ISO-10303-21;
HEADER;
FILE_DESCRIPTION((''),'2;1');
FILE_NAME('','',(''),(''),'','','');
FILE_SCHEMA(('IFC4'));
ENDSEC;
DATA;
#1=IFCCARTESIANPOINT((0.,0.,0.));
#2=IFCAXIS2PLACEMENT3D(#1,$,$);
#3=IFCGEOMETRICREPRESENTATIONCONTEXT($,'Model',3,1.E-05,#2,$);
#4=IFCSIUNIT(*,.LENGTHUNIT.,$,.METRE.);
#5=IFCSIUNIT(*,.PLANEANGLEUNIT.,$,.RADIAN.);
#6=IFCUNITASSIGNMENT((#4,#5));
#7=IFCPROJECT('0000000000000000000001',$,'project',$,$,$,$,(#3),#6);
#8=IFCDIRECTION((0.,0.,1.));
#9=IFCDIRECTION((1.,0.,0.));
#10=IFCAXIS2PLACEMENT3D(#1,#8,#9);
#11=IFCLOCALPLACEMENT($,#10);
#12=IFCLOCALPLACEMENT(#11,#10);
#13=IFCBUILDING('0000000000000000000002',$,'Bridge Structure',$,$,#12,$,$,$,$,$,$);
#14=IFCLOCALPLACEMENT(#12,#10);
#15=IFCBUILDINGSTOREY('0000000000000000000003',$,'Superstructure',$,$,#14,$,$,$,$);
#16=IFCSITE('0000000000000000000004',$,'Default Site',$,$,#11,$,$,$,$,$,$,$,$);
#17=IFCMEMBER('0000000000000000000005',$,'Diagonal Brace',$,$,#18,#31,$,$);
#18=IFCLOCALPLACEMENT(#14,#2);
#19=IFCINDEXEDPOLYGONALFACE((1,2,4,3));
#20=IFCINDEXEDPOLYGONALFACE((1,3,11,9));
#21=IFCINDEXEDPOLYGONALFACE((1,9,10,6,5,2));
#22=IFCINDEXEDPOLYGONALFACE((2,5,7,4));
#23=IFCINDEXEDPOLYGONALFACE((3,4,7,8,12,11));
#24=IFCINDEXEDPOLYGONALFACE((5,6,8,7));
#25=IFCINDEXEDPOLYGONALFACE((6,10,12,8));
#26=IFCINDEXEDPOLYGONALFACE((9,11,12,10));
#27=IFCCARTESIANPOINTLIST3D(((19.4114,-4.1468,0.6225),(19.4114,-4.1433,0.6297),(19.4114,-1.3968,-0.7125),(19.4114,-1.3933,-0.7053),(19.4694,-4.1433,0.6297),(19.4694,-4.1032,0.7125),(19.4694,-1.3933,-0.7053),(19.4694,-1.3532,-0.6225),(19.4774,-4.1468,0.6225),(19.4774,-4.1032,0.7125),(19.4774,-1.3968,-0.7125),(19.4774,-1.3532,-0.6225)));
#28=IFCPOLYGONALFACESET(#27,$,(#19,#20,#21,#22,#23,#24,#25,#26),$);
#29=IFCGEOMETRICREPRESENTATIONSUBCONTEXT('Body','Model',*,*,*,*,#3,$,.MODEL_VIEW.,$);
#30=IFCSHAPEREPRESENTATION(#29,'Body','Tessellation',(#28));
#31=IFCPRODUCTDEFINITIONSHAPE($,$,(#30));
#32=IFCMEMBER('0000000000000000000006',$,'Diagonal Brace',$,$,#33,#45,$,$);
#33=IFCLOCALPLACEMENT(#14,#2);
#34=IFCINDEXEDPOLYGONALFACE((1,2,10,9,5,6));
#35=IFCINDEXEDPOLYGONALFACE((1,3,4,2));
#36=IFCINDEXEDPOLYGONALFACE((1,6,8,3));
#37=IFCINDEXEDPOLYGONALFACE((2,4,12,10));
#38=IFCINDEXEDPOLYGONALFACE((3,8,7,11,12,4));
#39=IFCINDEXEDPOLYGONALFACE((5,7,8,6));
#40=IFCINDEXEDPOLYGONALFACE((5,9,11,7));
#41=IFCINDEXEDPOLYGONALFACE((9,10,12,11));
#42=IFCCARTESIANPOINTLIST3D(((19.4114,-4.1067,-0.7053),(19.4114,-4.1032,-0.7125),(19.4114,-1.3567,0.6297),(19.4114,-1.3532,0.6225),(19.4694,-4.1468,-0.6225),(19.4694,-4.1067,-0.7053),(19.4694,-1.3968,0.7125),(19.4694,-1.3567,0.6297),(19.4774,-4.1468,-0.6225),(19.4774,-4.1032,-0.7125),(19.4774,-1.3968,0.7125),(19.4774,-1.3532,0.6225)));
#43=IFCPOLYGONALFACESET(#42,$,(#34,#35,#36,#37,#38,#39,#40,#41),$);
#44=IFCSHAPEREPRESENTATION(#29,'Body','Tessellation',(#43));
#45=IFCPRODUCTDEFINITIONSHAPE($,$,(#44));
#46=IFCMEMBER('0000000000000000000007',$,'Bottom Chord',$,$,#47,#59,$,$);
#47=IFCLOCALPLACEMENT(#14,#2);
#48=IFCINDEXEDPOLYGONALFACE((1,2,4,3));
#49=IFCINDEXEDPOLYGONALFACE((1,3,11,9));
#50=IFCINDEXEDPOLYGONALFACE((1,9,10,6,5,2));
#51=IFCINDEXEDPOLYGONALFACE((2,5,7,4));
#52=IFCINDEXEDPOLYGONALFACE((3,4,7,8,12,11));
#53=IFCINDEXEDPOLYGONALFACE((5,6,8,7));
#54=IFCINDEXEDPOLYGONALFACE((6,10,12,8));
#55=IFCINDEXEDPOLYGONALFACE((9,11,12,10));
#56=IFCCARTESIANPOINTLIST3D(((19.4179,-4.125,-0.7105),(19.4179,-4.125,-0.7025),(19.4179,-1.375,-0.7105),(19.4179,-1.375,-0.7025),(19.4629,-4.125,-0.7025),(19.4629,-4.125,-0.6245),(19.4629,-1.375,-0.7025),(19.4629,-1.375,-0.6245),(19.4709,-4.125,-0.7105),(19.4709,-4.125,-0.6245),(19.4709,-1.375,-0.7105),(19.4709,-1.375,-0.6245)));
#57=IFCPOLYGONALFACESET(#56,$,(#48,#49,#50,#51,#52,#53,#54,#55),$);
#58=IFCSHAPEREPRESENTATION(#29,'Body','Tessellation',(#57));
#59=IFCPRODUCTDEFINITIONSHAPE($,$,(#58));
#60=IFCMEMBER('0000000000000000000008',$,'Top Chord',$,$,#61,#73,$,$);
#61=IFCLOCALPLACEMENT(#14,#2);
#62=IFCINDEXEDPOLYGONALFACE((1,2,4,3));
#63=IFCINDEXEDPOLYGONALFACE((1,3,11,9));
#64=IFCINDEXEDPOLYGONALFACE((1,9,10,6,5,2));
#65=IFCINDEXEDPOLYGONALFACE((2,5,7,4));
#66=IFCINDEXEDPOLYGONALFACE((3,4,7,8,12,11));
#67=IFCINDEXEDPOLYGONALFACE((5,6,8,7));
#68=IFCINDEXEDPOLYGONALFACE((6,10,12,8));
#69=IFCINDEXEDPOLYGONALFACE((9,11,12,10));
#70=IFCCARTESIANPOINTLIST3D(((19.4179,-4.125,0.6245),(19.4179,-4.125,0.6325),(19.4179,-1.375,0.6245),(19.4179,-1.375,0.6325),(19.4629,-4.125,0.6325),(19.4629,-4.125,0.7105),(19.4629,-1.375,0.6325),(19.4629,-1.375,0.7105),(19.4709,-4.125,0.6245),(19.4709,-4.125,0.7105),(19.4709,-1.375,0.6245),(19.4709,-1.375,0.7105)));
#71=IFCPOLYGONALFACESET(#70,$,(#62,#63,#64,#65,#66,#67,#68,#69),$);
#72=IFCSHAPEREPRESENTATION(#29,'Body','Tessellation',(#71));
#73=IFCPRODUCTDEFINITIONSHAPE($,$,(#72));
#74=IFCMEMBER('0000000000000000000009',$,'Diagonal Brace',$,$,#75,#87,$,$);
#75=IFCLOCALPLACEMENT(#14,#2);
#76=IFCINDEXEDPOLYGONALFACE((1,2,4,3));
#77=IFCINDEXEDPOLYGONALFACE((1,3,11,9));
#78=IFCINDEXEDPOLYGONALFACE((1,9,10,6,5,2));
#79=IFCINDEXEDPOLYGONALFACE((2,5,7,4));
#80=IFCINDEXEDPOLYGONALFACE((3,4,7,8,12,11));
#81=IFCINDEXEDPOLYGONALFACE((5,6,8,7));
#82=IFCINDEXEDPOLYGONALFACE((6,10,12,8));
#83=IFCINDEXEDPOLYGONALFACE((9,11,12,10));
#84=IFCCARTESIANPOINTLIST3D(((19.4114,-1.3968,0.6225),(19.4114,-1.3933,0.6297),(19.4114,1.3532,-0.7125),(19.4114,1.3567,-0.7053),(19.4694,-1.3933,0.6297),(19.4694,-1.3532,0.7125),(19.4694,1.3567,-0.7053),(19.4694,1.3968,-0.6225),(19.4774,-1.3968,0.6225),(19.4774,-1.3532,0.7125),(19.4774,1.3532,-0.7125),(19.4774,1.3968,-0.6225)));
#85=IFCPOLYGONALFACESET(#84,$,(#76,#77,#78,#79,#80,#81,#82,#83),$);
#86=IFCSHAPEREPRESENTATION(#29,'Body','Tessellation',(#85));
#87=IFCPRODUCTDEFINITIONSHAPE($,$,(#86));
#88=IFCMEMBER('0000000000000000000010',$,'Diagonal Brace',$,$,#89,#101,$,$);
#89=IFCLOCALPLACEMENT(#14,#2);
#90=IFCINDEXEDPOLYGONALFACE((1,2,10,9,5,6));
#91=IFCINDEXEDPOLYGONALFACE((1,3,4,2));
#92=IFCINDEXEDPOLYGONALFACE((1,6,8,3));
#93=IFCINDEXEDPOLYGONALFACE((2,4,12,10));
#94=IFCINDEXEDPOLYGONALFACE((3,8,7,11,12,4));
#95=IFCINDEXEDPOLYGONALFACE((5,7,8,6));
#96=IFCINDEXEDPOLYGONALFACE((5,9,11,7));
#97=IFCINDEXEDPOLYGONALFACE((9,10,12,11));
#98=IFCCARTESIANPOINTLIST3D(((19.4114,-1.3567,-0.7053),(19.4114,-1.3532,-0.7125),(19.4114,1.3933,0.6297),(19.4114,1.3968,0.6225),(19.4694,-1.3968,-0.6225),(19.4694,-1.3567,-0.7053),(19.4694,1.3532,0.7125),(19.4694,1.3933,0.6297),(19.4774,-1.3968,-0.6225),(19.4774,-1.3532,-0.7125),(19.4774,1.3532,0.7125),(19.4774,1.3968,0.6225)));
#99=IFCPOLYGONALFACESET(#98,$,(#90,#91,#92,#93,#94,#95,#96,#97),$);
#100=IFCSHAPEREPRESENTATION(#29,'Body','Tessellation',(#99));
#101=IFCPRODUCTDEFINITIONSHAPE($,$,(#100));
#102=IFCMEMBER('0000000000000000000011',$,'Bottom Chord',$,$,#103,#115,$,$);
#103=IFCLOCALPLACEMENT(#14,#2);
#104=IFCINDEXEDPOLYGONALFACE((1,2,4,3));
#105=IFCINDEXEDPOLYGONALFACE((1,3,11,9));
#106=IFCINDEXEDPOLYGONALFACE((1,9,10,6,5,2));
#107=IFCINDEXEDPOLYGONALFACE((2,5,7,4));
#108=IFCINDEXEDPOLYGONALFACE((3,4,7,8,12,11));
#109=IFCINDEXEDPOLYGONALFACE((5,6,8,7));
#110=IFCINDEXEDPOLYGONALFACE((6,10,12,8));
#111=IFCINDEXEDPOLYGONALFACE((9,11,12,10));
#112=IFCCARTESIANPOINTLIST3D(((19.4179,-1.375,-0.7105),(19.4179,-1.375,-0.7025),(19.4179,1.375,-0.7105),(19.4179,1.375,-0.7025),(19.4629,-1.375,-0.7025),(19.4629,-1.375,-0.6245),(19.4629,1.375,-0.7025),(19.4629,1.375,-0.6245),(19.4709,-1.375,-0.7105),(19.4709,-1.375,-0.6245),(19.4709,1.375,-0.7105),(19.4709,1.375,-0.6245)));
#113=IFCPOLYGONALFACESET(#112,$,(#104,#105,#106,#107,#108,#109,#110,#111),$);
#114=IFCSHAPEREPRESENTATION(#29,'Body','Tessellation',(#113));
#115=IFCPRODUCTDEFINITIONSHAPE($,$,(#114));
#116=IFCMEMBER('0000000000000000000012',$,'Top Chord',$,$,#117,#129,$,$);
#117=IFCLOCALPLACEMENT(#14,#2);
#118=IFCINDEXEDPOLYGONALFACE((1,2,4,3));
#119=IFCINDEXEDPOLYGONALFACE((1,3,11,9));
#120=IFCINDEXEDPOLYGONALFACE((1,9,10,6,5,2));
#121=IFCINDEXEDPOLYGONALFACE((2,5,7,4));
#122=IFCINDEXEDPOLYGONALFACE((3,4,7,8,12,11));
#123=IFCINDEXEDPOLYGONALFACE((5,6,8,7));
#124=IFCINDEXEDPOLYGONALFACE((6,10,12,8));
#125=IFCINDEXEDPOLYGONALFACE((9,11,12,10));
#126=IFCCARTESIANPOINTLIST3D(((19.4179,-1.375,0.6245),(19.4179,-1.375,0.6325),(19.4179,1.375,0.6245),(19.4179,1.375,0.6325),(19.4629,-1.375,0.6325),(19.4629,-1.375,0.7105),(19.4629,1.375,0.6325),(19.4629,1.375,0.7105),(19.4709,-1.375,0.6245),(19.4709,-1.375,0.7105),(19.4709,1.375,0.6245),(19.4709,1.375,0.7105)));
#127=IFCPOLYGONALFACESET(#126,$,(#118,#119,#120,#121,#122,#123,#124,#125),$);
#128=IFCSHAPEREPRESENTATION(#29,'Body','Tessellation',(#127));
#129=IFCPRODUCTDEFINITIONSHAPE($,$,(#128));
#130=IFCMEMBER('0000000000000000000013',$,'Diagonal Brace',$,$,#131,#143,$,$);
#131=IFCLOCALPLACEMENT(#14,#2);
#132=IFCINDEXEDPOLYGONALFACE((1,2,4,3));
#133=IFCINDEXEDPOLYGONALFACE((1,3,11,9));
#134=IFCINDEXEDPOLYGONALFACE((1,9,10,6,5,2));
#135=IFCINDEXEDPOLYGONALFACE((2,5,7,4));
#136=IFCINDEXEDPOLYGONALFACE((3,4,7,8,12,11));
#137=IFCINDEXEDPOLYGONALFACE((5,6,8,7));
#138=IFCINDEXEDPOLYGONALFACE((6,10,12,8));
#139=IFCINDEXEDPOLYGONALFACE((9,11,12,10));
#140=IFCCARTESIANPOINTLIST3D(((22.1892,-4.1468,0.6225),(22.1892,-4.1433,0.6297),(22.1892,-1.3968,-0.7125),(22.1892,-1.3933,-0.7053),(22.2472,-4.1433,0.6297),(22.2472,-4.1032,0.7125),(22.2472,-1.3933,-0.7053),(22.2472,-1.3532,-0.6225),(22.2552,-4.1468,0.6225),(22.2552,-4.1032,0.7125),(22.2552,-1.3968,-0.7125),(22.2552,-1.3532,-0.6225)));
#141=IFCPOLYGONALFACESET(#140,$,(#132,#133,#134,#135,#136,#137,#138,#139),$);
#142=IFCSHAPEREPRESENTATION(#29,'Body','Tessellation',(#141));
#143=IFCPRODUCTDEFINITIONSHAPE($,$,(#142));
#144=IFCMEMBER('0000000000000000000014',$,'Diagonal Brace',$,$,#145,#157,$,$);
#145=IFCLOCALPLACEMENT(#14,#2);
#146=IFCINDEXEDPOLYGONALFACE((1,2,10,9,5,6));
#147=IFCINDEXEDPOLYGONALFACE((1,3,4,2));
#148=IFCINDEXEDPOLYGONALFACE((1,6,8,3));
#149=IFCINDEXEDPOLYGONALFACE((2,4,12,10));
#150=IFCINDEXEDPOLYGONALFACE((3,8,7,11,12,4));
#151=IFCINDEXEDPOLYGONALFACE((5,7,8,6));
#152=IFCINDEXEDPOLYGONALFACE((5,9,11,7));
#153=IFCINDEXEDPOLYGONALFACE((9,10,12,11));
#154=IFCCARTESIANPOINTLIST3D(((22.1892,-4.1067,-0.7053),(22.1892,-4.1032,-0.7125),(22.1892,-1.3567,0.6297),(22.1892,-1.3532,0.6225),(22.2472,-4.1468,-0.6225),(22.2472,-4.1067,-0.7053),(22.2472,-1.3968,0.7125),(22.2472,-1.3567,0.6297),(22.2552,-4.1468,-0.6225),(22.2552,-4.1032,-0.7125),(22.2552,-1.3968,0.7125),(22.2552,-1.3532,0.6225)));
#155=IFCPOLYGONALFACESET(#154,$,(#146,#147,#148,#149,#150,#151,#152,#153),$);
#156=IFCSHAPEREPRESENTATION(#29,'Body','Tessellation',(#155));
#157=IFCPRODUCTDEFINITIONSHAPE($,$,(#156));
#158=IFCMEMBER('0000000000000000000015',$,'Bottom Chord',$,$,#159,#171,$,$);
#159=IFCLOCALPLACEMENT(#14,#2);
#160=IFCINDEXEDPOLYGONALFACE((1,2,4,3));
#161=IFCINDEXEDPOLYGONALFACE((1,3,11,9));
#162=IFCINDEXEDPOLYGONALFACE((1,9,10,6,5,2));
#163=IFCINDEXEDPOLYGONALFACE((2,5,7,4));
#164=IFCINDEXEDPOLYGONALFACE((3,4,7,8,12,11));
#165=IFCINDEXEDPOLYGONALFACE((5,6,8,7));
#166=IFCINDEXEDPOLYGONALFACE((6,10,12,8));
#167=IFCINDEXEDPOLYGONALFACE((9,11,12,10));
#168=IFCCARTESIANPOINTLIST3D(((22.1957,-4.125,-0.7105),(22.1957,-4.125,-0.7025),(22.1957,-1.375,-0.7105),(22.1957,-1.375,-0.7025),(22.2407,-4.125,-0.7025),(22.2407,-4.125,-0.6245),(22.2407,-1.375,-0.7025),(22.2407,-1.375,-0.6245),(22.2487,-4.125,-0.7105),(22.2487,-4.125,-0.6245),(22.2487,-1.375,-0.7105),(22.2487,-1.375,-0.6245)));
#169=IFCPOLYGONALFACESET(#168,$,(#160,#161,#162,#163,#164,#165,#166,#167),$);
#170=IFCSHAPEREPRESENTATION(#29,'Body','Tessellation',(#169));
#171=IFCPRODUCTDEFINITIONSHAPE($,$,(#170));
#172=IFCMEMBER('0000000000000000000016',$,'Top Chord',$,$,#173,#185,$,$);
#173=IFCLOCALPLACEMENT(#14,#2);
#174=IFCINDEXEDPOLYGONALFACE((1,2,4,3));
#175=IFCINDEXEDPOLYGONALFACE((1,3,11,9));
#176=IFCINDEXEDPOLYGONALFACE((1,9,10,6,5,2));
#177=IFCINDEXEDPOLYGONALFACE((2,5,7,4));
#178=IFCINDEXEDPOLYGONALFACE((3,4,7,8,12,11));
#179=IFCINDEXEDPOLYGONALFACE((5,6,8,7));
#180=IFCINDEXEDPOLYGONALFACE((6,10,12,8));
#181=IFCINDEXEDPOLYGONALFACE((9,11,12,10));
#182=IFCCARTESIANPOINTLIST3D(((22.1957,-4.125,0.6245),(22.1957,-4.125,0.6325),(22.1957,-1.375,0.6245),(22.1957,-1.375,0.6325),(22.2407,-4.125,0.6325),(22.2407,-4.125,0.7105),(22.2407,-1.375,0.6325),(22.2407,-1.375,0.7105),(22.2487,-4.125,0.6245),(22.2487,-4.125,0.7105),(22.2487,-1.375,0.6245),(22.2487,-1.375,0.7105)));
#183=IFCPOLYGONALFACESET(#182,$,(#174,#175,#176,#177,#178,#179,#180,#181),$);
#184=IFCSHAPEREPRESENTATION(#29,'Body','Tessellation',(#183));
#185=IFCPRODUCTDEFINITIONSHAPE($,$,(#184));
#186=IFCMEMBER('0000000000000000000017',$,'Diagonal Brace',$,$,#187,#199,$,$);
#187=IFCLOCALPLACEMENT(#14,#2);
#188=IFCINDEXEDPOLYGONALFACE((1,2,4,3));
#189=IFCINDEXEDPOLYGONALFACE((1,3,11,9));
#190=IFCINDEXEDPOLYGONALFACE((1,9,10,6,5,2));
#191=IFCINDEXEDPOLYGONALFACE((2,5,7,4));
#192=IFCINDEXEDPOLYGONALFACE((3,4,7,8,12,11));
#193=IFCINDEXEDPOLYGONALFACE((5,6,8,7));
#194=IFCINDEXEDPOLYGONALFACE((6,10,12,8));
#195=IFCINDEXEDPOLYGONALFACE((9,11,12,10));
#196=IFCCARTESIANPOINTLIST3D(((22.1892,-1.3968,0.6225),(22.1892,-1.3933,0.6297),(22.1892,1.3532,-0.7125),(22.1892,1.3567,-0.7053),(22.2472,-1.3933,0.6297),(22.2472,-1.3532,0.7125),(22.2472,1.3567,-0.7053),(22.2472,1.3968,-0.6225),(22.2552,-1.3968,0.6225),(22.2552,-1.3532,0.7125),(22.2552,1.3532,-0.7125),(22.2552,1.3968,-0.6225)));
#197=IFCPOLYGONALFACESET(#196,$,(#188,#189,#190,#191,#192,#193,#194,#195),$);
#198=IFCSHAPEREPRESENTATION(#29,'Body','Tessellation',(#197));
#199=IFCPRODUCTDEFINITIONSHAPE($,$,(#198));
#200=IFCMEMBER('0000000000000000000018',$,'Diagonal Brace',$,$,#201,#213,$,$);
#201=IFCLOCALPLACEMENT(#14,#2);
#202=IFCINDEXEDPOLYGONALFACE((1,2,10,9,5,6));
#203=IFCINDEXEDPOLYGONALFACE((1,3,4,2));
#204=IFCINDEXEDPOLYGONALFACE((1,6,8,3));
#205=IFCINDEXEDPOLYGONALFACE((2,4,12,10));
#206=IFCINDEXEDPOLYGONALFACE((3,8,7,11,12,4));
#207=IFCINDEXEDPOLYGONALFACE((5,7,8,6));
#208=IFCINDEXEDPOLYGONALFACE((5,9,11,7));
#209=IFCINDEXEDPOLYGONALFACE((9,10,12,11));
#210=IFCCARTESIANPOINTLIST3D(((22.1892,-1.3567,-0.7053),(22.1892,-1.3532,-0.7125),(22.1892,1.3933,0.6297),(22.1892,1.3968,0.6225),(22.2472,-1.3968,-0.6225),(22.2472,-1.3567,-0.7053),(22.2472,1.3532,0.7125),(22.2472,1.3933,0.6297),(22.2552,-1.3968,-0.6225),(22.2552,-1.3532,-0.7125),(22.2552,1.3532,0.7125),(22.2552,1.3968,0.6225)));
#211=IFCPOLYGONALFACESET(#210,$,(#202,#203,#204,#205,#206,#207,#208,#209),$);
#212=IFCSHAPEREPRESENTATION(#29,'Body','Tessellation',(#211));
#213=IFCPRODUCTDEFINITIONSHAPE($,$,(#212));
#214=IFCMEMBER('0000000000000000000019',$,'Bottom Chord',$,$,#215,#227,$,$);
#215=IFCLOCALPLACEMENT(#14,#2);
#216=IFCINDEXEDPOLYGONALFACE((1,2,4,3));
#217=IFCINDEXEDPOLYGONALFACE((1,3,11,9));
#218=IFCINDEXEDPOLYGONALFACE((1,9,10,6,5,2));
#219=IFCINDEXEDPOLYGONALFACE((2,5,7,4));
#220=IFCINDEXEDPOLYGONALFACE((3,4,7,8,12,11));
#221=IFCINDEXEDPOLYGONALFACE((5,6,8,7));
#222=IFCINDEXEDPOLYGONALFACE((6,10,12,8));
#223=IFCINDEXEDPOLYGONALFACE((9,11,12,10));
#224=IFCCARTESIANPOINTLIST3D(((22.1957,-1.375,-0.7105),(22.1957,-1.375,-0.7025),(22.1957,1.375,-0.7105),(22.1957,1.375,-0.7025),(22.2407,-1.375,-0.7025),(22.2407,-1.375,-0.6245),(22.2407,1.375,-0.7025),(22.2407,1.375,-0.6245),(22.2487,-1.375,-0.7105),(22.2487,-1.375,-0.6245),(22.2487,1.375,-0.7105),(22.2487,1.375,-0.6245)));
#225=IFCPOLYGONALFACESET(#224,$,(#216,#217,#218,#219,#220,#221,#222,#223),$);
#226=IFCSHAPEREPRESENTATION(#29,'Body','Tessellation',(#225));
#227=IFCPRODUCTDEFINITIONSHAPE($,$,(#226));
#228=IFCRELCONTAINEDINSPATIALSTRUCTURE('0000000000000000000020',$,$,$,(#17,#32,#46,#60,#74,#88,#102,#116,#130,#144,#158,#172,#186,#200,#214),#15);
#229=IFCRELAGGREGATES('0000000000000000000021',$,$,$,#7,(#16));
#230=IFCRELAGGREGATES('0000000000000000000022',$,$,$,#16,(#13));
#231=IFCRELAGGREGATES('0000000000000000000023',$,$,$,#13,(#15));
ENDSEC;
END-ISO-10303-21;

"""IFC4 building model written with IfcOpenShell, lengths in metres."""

from ifc_helpers import new_model, si_unit, frame, origin, origin_with_axes, origin_2d_with_axis, place, context, subcontext, project, spatial, l_section, extrude, element, save


model = new_model("IFC4")

# Units and contexts
model_context = context("Model", 3, precision=1e-05, world=origin())
body_context = subcontext(model_context, "Body", "Model", "MODEL_VIEW")
ifc_project = project(units=[si_unit("LENGTHUNIT", "METRE"), si_unit("PLANEANGLEUNIT", "RADIAN")], contexts=[model_context])

# Site, building, storey
site_placement = place(None, origin_with_axes())
site = spatial("IfcSite", under=ifc_project, at=site_placement, Name="Default Site")
building_placement = place(site_placement, origin_with_axes())
building = spatial("IfcBuilding", under=site, at=building_placement, Name="Bridge Structure")
storey_placement = place(building_placement, origin_with_axes())
storey = spatial("IfcBuildingStorey", under=building, at=storey_placement, Name="Superstructure")

# Members
for number, where, z_axis, x_axis, name in (
    (1, (19.4444, -4.125, 0.6675), (0.0, 0.8996, -0.436715), (-1.0, 0.0, 0.0), "Diagonal Brace"),
    (2, (19.4444, -4.125, -0.6675), (0.0, 0.8996, 0.436715), (-1.0, 0.0, 0.0), "Diagonal Brace"),
):
    element("IfcMember", number, at=place(storey_placement, frame(where, z_axis=z_axis, x_axis=x_axis)), inside=storey, Name=name, context=body_context, shape_type="SweptSolid", body=[
        extrude(l_section(Depth=0.1, Width=0.066, Thickness=0.008, at=origin_2d_with_axis()), origin_with_axes(), (0.0, 0.0, 1.0), 3.0569),
    ])
for number, where, z_axis, x_axis, name in (
    (3, (19.4444, -4.125, -0.6675), (0.0, 1.0, 0.0), (-1.0, 0.0, 0.0), "Bottom Chord"),
    (4, (19.4444, -4.125, 0.6675), (0.0, 1.0, 0.0), (-1.0, 0.0, 0.0), "Top Chord"),
):
    element("IfcMember", number, at=place(storey_placement, frame(where, z_axis=z_axis, x_axis=x_axis)), inside=storey, Name=name, context=body_context, shape_type="SweptSolid", body=[
        extrude(l_section(Depth=0.086, Width=0.053, Thickness=0.008, at=origin_2d_with_axis()), origin_with_axes(), (0.0, 0.0, 1.0), 2.75),
    ])
for number, where, z_axis, x_axis, name in (
    (5, (19.4444, -1.375, 0.6675), (0.0, 0.8996, -0.436715), (-1.0, 0.0, 0.0), "Diagonal Brace"),
    (6, (19.4444, -1.375, -0.6675), (0.0, 0.8996, 0.436715), (-1.0, 0.0, 0.0), "Diagonal Brace"),
):
    element("IfcMember", number, at=place(storey_placement, frame(where, z_axis=z_axis, x_axis=x_axis)), inside=storey, Name=name, context=body_context, shape_type="SweptSolid", body=[
        extrude(l_section(Depth=0.1, Width=0.066, Thickness=0.008, at=origin_2d_with_axis()), origin_with_axes(), (0.0, 0.0, 1.0), 3.0569),
    ])
for number, where, z_axis, x_axis, name in (
    (7, (19.4444, -1.375, -0.6675), (0.0, 1.0, 0.0), (-1.0, 0.0, 0.0), "Bottom Chord"),
    (8, (19.4444, -1.375, 0.6675), (0.0, 1.0, 0.0), (-1.0, 0.0, 0.0), "Top Chord"),
):
    element("IfcMember", number, at=place(storey_placement, frame(where, z_axis=z_axis, x_axis=x_axis)), inside=storey, Name=name, context=body_context, shape_type="SweptSolid", body=[
        extrude(l_section(Depth=0.086, Width=0.053, Thickness=0.008, at=origin_2d_with_axis()), origin_with_axes(), (0.0, 0.0, 1.0), 2.75),
    ])
for number, where, z_axis, x_axis, name in (
    (9, (22.2222, -4.125, 0.6675), (0.0, 0.8996, -0.436715), (-1.0, 0.0, 0.0), "Diagonal Brace"),
    (10, (22.2222, -4.125, -0.6675), (0.0, 0.8996, 0.436715), (-1.0, 0.0, 0.0), "Diagonal Brace"),
):
    element("IfcMember", number, at=place(storey_placement, frame(where, z_axis=z_axis, x_axis=x_axis)), inside=storey, Name=name, context=body_context, shape_type="SweptSolid", body=[
        extrude(l_section(Depth=0.1, Width=0.066, Thickness=0.008, at=origin_2d_with_axis()), origin_with_axes(), (0.0, 0.0, 1.0), 3.0569),
    ])
for number, where, z_axis, x_axis, name in (
    (11, (22.2222, -4.125, -0.6675), (0.0, 1.0, 0.0), (-1.0, 0.0, 0.0), "Bottom Chord"),
    (12, (22.2222, -4.125, 0.6675), (0.0, 1.0, 0.0), (-1.0, 0.0, 0.0), "Top Chord"),
):
    element("IfcMember", number, at=place(storey_placement, frame(where, z_axis=z_axis, x_axis=x_axis)), inside=storey, Name=name, context=body_context, shape_type="SweptSolid", body=[
        extrude(l_section(Depth=0.086, Width=0.053, Thickness=0.008, at=origin_2d_with_axis()), origin_with_axes(), (0.0, 0.0, 1.0), 2.75),
    ])
for number, where, z_axis, x_axis, name in (
    (13, (22.2222, -1.375, 0.6675), (0.0, 0.8996, -0.436715), (-1.0, 0.0, 0.0), "Diagonal Brace"),
    (14, (22.2222, -1.375, -0.6675), (0.0, 0.8996, 0.436715), (-1.0, 0.0, 0.0), "Diagonal Brace"),
):
    element("IfcMember", number, at=place(storey_placement, frame(where, z_axis=z_axis, x_axis=x_axis)), inside=storey, Name=name, context=body_context, shape_type="SweptSolid", body=[
        extrude(l_section(Depth=0.1, Width=0.066, Thickness=0.008, at=origin_2d_with_axis()), origin_with_axes(), (0.0, 0.0, 1.0), 3.0569),
    ])
for number, where, z_axis, x_axis, name in (
    (15, (22.2222, -1.375, -0.6675), (0.0, 1.0, 0.0), (-1.0, 0.0, 0.0), "Bottom Chord"),
):
    element("IfcMember", number, at=place(storey_placement, frame(where, z_axis=z_axis, x_axis=x_axis)), inside=storey, Name=name, context=body_context, shape_type="SweptSolid", body=[
        extrude(l_section(Depth=0.086, Width=0.053, Thickness=0.008, at=origin_2d_with_axis()), origin_with_axes(), (0.0, 0.0, 1.0), 2.75),
    ])

save(model, "model.ifc")
